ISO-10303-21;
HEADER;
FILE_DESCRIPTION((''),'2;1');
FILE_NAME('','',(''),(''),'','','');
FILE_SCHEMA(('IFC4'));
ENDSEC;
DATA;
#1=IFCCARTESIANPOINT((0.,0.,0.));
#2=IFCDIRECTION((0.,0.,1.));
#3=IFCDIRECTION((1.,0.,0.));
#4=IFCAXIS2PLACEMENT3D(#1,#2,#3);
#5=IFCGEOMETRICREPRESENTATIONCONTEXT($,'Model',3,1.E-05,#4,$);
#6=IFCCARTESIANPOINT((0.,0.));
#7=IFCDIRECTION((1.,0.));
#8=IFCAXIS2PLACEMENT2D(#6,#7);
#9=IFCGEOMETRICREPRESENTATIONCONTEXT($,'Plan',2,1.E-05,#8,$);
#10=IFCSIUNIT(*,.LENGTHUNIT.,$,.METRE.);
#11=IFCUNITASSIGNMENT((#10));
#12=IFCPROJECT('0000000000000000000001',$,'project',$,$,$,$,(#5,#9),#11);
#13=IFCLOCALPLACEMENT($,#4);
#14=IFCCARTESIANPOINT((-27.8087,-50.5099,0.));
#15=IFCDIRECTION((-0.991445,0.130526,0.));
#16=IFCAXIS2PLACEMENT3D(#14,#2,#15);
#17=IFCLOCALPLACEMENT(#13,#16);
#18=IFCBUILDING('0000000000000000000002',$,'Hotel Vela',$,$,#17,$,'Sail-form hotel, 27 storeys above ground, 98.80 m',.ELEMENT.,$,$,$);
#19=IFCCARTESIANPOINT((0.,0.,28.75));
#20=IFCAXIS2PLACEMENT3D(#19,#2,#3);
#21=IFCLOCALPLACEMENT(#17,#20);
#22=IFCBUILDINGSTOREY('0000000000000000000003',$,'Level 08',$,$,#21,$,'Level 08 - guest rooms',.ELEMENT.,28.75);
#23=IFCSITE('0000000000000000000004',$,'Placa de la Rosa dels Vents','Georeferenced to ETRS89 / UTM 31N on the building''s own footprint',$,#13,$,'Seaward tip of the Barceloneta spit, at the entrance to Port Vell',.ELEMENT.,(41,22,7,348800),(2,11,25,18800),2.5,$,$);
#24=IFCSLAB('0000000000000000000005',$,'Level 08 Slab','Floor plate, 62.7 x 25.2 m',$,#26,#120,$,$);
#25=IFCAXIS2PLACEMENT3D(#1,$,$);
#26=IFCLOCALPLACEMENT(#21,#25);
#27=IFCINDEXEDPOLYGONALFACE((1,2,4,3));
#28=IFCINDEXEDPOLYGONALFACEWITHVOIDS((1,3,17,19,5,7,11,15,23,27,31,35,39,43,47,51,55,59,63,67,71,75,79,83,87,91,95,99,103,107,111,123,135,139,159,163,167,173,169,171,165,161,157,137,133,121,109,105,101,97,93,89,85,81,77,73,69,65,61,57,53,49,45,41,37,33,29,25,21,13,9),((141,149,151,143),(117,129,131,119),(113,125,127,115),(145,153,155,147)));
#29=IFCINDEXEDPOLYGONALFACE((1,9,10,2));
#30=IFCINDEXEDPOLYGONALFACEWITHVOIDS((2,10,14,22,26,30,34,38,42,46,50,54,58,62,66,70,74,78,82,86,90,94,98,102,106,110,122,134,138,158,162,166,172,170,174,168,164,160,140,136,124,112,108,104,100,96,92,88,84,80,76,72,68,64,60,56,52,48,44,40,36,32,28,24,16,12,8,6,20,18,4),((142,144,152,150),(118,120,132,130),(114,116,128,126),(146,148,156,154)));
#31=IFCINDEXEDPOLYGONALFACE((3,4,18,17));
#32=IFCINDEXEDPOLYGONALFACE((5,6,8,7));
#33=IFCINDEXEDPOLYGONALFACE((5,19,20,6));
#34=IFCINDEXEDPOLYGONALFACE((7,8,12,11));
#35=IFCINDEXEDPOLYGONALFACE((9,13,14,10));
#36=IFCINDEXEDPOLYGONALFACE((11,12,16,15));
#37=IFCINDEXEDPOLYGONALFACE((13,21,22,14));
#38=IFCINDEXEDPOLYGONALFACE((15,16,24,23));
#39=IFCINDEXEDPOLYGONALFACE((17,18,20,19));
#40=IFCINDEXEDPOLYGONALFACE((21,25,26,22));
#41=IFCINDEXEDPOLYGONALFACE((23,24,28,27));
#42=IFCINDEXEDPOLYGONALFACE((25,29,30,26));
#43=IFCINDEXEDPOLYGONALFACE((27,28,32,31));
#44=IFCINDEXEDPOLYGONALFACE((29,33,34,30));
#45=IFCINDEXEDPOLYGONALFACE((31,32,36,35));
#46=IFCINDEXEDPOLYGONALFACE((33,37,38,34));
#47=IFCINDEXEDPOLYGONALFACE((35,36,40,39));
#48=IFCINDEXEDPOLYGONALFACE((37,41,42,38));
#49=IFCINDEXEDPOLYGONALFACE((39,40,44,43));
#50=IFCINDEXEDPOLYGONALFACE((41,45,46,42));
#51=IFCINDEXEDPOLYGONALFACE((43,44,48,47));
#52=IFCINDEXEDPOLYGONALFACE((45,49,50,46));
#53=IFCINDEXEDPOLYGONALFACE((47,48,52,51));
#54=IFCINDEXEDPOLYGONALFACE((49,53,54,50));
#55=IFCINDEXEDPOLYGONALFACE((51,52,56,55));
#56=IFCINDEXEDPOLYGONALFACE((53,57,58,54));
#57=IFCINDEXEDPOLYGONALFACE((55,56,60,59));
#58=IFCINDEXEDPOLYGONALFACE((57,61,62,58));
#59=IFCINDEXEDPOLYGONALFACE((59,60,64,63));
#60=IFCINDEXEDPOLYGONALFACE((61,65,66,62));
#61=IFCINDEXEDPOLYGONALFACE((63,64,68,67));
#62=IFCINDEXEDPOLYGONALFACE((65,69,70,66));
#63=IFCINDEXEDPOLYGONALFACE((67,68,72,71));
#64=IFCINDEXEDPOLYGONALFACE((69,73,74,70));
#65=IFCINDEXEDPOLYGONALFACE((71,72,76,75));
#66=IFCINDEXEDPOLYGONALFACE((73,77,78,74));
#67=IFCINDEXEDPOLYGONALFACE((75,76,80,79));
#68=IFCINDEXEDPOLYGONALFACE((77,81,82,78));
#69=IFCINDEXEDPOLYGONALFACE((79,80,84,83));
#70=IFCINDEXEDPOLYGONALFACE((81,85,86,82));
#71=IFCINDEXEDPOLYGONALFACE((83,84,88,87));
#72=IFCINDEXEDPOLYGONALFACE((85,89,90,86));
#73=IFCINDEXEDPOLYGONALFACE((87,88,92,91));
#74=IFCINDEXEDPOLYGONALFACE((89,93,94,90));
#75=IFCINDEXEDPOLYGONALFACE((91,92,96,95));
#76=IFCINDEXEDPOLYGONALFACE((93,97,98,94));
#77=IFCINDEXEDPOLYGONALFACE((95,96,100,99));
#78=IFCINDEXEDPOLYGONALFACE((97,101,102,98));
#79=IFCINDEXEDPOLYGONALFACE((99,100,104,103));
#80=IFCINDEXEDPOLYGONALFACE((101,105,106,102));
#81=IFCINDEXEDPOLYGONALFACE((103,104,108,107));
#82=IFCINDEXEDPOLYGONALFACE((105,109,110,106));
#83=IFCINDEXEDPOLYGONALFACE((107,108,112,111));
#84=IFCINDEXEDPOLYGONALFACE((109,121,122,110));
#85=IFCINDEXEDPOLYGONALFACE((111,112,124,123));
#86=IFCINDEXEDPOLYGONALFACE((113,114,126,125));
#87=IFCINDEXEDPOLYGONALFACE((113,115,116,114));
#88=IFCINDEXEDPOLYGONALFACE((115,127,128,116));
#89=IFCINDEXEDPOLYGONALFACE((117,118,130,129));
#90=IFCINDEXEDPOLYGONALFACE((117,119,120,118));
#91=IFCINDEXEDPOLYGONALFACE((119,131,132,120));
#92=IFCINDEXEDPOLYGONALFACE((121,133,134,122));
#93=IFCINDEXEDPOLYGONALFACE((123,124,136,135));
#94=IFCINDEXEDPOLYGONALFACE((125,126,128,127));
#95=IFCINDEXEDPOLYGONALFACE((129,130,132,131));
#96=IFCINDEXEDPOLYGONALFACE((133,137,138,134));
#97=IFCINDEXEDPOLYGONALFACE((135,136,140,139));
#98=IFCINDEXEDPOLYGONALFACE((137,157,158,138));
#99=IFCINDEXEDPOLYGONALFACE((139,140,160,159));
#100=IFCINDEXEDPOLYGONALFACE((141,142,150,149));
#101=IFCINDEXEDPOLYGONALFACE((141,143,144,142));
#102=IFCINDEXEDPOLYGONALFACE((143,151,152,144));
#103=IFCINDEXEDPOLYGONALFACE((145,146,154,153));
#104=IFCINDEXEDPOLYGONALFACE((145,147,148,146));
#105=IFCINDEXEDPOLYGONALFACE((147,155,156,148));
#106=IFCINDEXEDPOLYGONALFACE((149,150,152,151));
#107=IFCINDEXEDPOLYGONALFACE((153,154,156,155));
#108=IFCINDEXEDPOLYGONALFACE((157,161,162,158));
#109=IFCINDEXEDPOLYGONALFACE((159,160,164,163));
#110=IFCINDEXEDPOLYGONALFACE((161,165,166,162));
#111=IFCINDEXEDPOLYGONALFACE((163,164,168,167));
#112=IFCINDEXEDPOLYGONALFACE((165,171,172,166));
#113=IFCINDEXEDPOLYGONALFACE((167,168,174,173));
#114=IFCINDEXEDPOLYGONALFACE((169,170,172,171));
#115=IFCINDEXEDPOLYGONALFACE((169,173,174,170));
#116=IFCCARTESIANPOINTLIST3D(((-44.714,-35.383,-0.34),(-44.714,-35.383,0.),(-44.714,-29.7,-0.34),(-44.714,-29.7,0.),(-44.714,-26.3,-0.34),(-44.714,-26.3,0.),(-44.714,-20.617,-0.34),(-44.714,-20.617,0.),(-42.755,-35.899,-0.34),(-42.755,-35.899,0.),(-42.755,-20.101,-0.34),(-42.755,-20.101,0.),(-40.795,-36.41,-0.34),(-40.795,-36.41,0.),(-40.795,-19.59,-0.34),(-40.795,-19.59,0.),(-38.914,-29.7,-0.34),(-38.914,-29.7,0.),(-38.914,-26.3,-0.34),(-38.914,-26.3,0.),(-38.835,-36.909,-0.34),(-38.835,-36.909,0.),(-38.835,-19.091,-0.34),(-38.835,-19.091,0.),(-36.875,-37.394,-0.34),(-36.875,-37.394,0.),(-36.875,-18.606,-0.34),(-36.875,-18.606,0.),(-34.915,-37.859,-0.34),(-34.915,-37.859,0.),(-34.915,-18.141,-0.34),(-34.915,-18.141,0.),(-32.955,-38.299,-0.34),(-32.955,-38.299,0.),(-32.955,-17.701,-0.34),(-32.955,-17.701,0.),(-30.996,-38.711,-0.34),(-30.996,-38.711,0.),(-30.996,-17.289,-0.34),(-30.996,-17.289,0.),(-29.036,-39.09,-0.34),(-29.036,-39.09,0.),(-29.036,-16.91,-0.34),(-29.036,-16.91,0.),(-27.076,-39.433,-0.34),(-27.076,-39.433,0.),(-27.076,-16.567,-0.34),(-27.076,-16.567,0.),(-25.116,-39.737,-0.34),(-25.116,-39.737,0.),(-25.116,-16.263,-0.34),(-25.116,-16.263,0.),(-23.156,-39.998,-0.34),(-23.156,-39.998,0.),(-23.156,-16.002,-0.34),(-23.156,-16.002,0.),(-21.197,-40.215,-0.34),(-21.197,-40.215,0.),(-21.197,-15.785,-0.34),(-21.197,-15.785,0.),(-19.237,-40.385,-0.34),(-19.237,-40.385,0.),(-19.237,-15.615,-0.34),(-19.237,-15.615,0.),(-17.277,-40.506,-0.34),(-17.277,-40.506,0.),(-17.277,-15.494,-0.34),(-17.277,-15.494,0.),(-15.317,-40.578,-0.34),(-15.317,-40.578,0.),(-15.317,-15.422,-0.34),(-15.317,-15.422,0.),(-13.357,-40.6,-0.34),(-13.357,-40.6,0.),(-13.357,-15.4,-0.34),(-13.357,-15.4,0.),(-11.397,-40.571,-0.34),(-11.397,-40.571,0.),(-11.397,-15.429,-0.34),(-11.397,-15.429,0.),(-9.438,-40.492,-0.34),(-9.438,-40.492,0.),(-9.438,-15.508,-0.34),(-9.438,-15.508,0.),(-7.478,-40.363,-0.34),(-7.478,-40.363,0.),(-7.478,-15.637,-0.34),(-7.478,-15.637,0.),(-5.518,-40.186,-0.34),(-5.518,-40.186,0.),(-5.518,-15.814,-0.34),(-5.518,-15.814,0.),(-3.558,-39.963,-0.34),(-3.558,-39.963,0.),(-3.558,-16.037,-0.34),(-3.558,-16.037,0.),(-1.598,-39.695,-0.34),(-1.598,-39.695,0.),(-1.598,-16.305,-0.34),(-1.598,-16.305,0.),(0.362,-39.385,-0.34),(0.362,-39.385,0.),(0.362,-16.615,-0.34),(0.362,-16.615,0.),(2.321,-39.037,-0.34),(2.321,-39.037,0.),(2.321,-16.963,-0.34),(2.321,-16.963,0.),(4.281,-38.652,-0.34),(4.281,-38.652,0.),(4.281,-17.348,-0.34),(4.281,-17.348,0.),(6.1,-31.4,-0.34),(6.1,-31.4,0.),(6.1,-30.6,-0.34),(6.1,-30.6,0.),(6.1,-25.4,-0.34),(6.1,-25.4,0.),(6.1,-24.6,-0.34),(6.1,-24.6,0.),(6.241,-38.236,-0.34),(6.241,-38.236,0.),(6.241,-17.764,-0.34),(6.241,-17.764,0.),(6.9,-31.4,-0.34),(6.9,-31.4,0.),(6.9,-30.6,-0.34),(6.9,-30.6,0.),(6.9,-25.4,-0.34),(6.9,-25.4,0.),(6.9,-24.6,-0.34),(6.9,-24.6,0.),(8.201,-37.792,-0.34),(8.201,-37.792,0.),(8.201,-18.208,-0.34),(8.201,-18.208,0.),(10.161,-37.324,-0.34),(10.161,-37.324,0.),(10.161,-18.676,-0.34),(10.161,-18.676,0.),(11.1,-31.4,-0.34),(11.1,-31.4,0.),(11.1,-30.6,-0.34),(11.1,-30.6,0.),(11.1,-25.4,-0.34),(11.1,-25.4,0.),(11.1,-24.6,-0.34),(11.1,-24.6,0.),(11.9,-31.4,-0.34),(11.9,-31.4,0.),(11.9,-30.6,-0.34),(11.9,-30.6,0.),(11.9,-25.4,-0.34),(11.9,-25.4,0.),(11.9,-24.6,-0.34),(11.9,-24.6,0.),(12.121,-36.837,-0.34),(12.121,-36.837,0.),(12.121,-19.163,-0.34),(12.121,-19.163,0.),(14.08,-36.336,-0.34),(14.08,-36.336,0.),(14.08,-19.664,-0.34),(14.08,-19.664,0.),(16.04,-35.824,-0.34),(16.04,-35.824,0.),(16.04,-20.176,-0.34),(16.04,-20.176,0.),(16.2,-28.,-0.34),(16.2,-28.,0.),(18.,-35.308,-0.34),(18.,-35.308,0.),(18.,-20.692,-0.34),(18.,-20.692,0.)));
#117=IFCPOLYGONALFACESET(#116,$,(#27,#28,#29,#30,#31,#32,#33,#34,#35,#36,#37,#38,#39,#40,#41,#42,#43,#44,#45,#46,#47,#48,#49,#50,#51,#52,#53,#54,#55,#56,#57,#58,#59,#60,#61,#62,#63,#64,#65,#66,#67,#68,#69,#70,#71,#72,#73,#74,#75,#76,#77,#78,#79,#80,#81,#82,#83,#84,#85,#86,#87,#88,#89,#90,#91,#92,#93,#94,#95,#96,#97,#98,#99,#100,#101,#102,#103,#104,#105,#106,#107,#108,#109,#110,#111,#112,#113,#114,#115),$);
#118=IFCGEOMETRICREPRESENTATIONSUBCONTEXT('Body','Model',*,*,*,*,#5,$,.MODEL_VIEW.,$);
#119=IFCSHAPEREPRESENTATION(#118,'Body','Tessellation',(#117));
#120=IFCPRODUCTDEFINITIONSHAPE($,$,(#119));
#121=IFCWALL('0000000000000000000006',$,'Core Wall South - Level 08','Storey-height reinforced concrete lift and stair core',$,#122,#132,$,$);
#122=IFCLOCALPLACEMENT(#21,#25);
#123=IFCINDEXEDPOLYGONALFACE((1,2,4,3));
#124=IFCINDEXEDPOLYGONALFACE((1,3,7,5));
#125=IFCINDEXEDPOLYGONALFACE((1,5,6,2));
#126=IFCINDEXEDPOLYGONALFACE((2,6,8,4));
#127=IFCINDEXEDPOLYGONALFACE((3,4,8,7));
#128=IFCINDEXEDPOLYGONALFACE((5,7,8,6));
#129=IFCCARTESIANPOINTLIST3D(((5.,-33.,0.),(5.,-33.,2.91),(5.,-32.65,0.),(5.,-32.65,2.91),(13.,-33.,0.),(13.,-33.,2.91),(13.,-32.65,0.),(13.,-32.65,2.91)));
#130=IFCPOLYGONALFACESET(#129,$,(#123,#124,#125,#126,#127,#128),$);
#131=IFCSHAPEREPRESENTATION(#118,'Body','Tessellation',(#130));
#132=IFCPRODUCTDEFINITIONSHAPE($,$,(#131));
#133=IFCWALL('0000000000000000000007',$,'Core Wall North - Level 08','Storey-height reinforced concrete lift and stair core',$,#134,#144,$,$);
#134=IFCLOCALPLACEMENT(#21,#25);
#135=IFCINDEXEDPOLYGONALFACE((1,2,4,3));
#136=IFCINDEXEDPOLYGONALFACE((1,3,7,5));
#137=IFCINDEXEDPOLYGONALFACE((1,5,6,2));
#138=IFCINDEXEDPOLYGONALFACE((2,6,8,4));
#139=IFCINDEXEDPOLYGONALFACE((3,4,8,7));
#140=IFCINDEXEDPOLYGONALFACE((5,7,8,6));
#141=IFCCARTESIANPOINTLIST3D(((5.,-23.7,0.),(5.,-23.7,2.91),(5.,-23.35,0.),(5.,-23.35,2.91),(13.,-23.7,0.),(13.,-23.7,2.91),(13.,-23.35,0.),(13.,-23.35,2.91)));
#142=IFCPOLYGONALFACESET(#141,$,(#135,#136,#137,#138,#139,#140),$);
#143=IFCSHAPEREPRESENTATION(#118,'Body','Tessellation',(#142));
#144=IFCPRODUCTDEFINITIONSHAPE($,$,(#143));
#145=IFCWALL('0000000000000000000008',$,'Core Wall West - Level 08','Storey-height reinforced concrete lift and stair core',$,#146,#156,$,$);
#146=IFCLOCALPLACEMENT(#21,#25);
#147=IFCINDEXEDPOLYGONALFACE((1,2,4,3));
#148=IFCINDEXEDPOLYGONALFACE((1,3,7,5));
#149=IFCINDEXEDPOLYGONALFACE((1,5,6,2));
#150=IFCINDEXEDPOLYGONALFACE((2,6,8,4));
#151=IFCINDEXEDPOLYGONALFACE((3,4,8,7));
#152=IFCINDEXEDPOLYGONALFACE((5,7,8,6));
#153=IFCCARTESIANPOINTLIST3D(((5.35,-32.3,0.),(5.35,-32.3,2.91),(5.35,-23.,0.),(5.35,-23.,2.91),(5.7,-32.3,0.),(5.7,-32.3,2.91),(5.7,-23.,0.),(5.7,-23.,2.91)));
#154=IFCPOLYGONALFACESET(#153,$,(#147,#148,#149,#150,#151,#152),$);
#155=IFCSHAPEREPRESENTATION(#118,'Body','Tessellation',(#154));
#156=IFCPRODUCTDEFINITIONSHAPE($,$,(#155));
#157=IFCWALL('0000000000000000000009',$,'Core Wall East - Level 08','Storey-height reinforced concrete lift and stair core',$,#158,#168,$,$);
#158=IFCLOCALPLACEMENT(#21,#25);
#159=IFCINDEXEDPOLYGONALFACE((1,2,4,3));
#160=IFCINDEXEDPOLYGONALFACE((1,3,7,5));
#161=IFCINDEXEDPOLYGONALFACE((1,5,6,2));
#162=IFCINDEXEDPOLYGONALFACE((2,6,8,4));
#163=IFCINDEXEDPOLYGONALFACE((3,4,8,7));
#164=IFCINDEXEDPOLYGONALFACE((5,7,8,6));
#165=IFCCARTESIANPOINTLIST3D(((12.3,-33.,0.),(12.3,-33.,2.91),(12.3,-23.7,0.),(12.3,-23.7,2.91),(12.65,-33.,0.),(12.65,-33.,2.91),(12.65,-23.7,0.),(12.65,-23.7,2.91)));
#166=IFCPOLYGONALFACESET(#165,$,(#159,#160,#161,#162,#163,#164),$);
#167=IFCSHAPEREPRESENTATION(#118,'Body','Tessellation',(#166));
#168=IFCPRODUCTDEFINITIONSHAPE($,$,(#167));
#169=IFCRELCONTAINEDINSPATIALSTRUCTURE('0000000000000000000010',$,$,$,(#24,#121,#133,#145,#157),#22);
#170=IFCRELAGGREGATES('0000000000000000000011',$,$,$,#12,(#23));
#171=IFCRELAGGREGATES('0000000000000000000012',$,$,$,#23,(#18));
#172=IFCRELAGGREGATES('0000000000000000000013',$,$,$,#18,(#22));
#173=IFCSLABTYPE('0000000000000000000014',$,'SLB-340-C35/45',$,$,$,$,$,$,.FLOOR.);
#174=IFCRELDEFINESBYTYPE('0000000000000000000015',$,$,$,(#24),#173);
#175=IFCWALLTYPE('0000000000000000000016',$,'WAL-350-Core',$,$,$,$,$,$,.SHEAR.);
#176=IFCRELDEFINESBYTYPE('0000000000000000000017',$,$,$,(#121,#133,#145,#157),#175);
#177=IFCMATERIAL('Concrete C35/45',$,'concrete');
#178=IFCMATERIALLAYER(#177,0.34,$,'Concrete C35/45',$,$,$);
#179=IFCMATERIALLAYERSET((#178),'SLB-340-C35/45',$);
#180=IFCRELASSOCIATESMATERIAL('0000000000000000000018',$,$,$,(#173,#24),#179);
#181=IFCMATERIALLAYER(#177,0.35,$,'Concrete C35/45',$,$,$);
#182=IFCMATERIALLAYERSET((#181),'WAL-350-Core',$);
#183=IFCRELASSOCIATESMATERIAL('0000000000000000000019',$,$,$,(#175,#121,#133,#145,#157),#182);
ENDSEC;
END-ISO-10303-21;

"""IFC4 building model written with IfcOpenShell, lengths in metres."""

from ifc_helpers import new_model, si_unit, frame, origin_with_axes, origin_2d_with_axis, place, context, subcontext, project, spatial, line, indexed_curve, outline, extrude, material, layer, layer_set, layer_usage, type_object, element, save


model = new_model("IFC4")

# Units and contexts
model_context = context("Model", 3, precision=1e-05, world=origin_with_axes())
plan_context = context("Plan", 2, precision=1e-05, world=origin_2d_with_axis())
body_context = subcontext(model_context, "Body", "Model", "MODEL_VIEW")
ifc_project = project(units=[si_unit("LENGTHUNIT", "METRE")], contexts=[model_context, plan_context])

# Site, building, storey
site_placement = place(None, origin_with_axes())
site = spatial("IfcSite", under=ifc_project, at=site_placement, Name="Placa de la Rosa dels Vents", Description="Georeferenced to ETRS89 / UTM 31N on the building's own footprint", LongName="Seaward tip of the Barceloneta spit, at the entrance to Port Vell", CompositionType="ELEMENT", RefLatitude=(41, 22, 7, 348800), RefLongitude=(2, 11, 25, 18800), RefElevation=2.5)
building_placement = place(site_placement, frame((-27.8087, -50.5099, 0.0), z_axis=(0.0, 0.0, 1.0), x_axis=(-0.991445, 0.130526, 0.0)))
building = spatial("IfcBuilding", under=site, at=building_placement, Name="Hotel Vela", LongName="Sail-form hotel, 27 storeys above ground, 98.80 m", CompositionType="ELEMENT")
storey_placement = place(building_placement, frame((0.0, 0.0, 28.75), z_axis=(0.0, 0.0, 1.0), x_axis=(1.0, 0.0, 0.0)))
storey = spatial("IfcBuildingStorey", under=building, at=storey_placement, Name="Level 08", LongName="Level 08 - guest rooms", CompositionType="ELEMENT", Elevation=28.75)

# Shared definitions
ifc_material = material(Name="Concrete C35/45", Category="concrete")

# Slab, openings
ifc_layer_1 = layer(ifc_material, 0.34, Name="Concrete C35/45")
ifc_layer_set_1 = layer_set([ifc_layer_1], Name="SLB-340-C35/45")
ifc_layer_usage_1 = layer_usage(ifc_layer_set_1, "AXIS3", "POSITIVE", 0.0)
slab_type = type_object("IfcSlabType", Name="SLB-340-C35/45", PredefinedType="FLOOR", material=ifc_layer_set_1)
slab_placement = place(storey_placement, frame((0.0, 0.0, -0.34), z_axis=(0.0, 0.0, 1.0), x_axis=(1.0, 0.0, 0.0)))
slab = element("IfcSlab", 1, at=slab_placement, inside=storey, type_object=slab_type, material=ifc_layer_usage_1, Name="Level 08 Slab", Description="Floor plate, 62.7 x 25.2 m", context=body_context, shape_type="SweptSolid", body=[
    extrude(outline(indexed_curve([(-44.714, -35.383), (-42.755, -35.899), (-40.795, -36.41), (-38.835, -36.909), (-36.875, -37.394), (-34.915, -37.859), (-32.955, -38.299), (-30.996, -38.711), (-29.036, -39.09), (-27.076, -39.433), (-25.116, -39.737), (-23.156, -39.998), (-21.197, -40.215), (-19.237, -40.385), (-17.277, -40.506), (-15.317, -40.578), (-13.357, -40.6), (-11.397, -40.571), (-9.438, -40.492), (-7.478, -40.363), (-5.518, -40.186), (-3.558, -39.963), (-1.598, -39.695), (0.362, -39.385), (2.321, -39.037), (4.281, -38.652), (6.241, -38.236), (8.201, -37.792), (10.161, -37.324), (12.121, -36.837), (14.08, -36.336), (16.04, -35.824), (18.0, -35.308), (16.2, -28.0), (18.0, -20.692), (16.04, -20.176), (14.08, -19.664), (12.121, -19.163), (10.161, -18.676), (8.201, -18.208), (6.241, -17.764), (4.281, -17.348), (2.321, -16.963), (0.362, -16.615), (-1.598, -16.305), (-3.558, -16.037), (-5.518, -15.814), (-7.478, -15.637), (-9.438, -15.508), (-11.397, -15.429), (-13.357, -15.4), (-15.317, -15.422), (-17.277, -15.494), (-19.237, -15.615), (-21.197, -15.785), (-23.156, -16.002), (-25.116, -16.263), (-27.076, -16.567), (-29.036, -16.91), (-30.996, -17.289), (-32.955, -17.701), (-34.915, -18.141), (-36.875, -18.606), (-38.835, -19.091), (-40.795, -19.59), (-42.755, -20.101), (-44.714, -20.617), (-44.714, -26.3), (-38.914, -26.3), (-38.914, -29.7), (-44.714, -29.7)], segments=[line(1, 2, 3, 4, 5, 6, 7, 8, 9, 10, 11, 12, 13, 14, 15, 16, 17, 18, 19, 20, 21, 22, 23, 24, 25, 26, 27, 28, 29, 30, 31, 32, 33, 34, 35, 36, 37, 38, 39, 40, 41, 42, 43, 44, 45, 46, 47, 48, 49, 50, 51, 52, 53, 54, 55, 56, 57, 58, 59, 60, 61, 62, 63, 64, 65, 66, 67, 68, 69, 70, 71, 1)])), origin_with_axes(), (0.0, 0.0, 1.0), 0.34),
])
opening_1_placement = place(slab_placement, frame((6.1, -31.4, -0.05), z_axis=(0.0, 0.0, 1.0), x_axis=(1.0, 0.0, 0.0)))
element("IfcOpeningElement", 2, at=opening_1_placement, cuts=slab, PredefinedType="OPENING", context=body_context, shape_type="SweptSolid", body=[
    extrude(outline(indexed_curve([(0.0, 0.0), (0.8, 0.0), (0.8, 0.8), (0.0, 0.8)], segments=[line(1, 2, 3, 4, 1)])), origin_with_axes(), (0.0, 0.0, 1.0), 0.44),
])
opening_2_placement = place(slab_placement, frame((6.1, -25.4, -0.05), z_axis=(0.0, 0.0, 1.0), x_axis=(1.0, 0.0, 0.0)))
element("IfcOpeningElement", 3, at=opening_2_placement, cuts=slab, PredefinedType="OPENING", context=body_context, shape_type="SweptSolid", body=[
    extrude(outline(indexed_curve([(0.0, 0.0), (0.8, 0.0), (0.8, 0.8), (0.0, 0.8)], segments=[line(1, 2, 3, 4, 1)])), origin_with_axes(), (0.0, 0.0, 1.0), 0.44),
])
opening_3_placement = place(slab_placement, frame((11.1, -31.4, -0.05), z_axis=(0.0, 0.0, 1.0), x_axis=(1.0, 0.0, 0.0)))
element("IfcOpeningElement", 4, at=opening_3_placement, cuts=slab, PredefinedType="OPENING", context=body_context, shape_type="SweptSolid", body=[
    extrude(outline(indexed_curve([(0.0, 0.0), (0.8, 0.0), (0.8, 0.8), (0.0, 0.8)], segments=[line(1, 2, 3, 4, 1)])), origin_with_axes(), (0.0, 0.0, 1.0), 0.44),
])
opening_4_placement = place(slab_placement, frame((11.1, -25.4, -0.05), z_axis=(0.0, 0.0, 1.0), x_axis=(1.0, 0.0, 0.0)))
element("IfcOpeningElement", 5, at=opening_4_placement, cuts=slab, PredefinedType="OPENING", context=body_context, shape_type="SweptSolid", body=[
    extrude(outline(indexed_curve([(0.0, 0.0), (0.8, 0.0), (0.8, 0.8), (0.0, 0.8)], segments=[line(1, 2, 3, 4, 1)])), origin_with_axes(), (0.0, 0.0, 1.0), 0.44),
])

# Walls
ifc_layer_2 = layer(ifc_material, 0.35, Name="Concrete C35/45")
ifc_layer_set_2 = layer_set([ifc_layer_2], Name="WAL-350-Core")
ifc_layer_usage_2 = layer_usage(ifc_layer_set_2, "AXIS2", "POSITIVE", 0.0)
wall_type = type_object("IfcWallType", Name="WAL-350-Core", PredefinedType="SHEAR", material=ifc_layer_set_2)
wall_1_placement = place(storey_placement, frame((5.0, -33.0, 0.0), z_axis=(0.0, 0.0, 1.0), x_axis=(1.0, 0.0, 0.0)))
element("IfcWall", 6, at=wall_1_placement, inside=storey, type_object=wall_type, material=ifc_layer_usage_2, Name="Core Wall South - Level 08", Description="Storey-height reinforced concrete lift and stair core", context=body_context, shape_type="SweptSolid", body=[
    extrude(outline(indexed_curve([(0.0, 0.0), (8.0, 0.0), (8.0, 0.35), (0.0, 0.35)], segments=[line(1, 2, 3, 4, 1)])), origin_with_axes(), (0.0, 0.0, 1.0), 2.91),
])
ifc_layer_usage_3 = layer_usage(ifc_layer_set_2, "AXIS2", "POSITIVE", 0.0)
wall_2_placement = place(storey_placement, frame((13.0, -23.35, 0.0), z_axis=(0.0, 0.0, 1.0), x_axis=(-1.0, 0.0, 0.0)))
element("IfcWall", 7, at=wall_2_placement, inside=storey, type_object=wall_type, material=ifc_layer_usage_3, Name="Core Wall North - Level 08", Description="Storey-height reinforced concrete lift and stair core", context=body_context, shape_type="SweptSolid", body=[
    extrude(outline(indexed_curve([(0.0, 0.0), (8.0, 0.0), (8.0, 0.35), (0.0, 0.35)], segments=[line(1, 2, 3, 4, 1)])), origin_with_axes(), (0.0, 0.0, 1.0), 2.91),
])
ifc_layer_usage_4 = layer_usage(ifc_layer_set_2, "AXIS2", "POSITIVE", 0.0)
wall_3_placement = place(storey_placement, frame((5.35, -23.0, 0.0), z_axis=(0.0, 0.0, 1.0), x_axis=(0.0, -1.0, 0.0)))
element("IfcWall", 8, at=wall_3_placement, inside=storey, type_object=wall_type, material=ifc_layer_usage_4, Name="Core Wall West - Level 08", Description="Storey-height reinforced concrete lift and stair core", context=body_context, shape_type="SweptSolid", body=[
    extrude(outline(indexed_curve([(0.0, 0.0), (9.3, 0.0), (9.3, 0.35), (0.0, 0.35)], segments=[line(1, 2, 3, 4, 1)])), origin_with_axes(), (0.0, 0.0, 1.0), 2.91),
])
ifc_layer_usage_5 = layer_usage(ifc_layer_set_2, "AXIS2", "POSITIVE", 0.0)
wall_4_placement = place(storey_placement, frame((12.65, -33.0, 0.0), z_axis=(0.0, 0.0, 1.0), x_axis=(0.0, 1.0, 0.0)))
element("IfcWall", 9, at=wall_4_placement, inside=storey, type_object=wall_type, material=ifc_layer_usage_5, Name="Core Wall East - Level 08", Description="Storey-height reinforced concrete lift and stair core", context=body_context, shape_type="SweptSolid", body=[
    extrude(outline(indexed_curve([(0.0, 0.0), (9.3, 0.0), (9.3, 0.35), (0.0, 0.35)], segments=[line(1, 2, 3, 4, 1)])), origin_with_axes(), (0.0, 0.0, 1.0), 2.91),
])

save(model, "model.ifc")
